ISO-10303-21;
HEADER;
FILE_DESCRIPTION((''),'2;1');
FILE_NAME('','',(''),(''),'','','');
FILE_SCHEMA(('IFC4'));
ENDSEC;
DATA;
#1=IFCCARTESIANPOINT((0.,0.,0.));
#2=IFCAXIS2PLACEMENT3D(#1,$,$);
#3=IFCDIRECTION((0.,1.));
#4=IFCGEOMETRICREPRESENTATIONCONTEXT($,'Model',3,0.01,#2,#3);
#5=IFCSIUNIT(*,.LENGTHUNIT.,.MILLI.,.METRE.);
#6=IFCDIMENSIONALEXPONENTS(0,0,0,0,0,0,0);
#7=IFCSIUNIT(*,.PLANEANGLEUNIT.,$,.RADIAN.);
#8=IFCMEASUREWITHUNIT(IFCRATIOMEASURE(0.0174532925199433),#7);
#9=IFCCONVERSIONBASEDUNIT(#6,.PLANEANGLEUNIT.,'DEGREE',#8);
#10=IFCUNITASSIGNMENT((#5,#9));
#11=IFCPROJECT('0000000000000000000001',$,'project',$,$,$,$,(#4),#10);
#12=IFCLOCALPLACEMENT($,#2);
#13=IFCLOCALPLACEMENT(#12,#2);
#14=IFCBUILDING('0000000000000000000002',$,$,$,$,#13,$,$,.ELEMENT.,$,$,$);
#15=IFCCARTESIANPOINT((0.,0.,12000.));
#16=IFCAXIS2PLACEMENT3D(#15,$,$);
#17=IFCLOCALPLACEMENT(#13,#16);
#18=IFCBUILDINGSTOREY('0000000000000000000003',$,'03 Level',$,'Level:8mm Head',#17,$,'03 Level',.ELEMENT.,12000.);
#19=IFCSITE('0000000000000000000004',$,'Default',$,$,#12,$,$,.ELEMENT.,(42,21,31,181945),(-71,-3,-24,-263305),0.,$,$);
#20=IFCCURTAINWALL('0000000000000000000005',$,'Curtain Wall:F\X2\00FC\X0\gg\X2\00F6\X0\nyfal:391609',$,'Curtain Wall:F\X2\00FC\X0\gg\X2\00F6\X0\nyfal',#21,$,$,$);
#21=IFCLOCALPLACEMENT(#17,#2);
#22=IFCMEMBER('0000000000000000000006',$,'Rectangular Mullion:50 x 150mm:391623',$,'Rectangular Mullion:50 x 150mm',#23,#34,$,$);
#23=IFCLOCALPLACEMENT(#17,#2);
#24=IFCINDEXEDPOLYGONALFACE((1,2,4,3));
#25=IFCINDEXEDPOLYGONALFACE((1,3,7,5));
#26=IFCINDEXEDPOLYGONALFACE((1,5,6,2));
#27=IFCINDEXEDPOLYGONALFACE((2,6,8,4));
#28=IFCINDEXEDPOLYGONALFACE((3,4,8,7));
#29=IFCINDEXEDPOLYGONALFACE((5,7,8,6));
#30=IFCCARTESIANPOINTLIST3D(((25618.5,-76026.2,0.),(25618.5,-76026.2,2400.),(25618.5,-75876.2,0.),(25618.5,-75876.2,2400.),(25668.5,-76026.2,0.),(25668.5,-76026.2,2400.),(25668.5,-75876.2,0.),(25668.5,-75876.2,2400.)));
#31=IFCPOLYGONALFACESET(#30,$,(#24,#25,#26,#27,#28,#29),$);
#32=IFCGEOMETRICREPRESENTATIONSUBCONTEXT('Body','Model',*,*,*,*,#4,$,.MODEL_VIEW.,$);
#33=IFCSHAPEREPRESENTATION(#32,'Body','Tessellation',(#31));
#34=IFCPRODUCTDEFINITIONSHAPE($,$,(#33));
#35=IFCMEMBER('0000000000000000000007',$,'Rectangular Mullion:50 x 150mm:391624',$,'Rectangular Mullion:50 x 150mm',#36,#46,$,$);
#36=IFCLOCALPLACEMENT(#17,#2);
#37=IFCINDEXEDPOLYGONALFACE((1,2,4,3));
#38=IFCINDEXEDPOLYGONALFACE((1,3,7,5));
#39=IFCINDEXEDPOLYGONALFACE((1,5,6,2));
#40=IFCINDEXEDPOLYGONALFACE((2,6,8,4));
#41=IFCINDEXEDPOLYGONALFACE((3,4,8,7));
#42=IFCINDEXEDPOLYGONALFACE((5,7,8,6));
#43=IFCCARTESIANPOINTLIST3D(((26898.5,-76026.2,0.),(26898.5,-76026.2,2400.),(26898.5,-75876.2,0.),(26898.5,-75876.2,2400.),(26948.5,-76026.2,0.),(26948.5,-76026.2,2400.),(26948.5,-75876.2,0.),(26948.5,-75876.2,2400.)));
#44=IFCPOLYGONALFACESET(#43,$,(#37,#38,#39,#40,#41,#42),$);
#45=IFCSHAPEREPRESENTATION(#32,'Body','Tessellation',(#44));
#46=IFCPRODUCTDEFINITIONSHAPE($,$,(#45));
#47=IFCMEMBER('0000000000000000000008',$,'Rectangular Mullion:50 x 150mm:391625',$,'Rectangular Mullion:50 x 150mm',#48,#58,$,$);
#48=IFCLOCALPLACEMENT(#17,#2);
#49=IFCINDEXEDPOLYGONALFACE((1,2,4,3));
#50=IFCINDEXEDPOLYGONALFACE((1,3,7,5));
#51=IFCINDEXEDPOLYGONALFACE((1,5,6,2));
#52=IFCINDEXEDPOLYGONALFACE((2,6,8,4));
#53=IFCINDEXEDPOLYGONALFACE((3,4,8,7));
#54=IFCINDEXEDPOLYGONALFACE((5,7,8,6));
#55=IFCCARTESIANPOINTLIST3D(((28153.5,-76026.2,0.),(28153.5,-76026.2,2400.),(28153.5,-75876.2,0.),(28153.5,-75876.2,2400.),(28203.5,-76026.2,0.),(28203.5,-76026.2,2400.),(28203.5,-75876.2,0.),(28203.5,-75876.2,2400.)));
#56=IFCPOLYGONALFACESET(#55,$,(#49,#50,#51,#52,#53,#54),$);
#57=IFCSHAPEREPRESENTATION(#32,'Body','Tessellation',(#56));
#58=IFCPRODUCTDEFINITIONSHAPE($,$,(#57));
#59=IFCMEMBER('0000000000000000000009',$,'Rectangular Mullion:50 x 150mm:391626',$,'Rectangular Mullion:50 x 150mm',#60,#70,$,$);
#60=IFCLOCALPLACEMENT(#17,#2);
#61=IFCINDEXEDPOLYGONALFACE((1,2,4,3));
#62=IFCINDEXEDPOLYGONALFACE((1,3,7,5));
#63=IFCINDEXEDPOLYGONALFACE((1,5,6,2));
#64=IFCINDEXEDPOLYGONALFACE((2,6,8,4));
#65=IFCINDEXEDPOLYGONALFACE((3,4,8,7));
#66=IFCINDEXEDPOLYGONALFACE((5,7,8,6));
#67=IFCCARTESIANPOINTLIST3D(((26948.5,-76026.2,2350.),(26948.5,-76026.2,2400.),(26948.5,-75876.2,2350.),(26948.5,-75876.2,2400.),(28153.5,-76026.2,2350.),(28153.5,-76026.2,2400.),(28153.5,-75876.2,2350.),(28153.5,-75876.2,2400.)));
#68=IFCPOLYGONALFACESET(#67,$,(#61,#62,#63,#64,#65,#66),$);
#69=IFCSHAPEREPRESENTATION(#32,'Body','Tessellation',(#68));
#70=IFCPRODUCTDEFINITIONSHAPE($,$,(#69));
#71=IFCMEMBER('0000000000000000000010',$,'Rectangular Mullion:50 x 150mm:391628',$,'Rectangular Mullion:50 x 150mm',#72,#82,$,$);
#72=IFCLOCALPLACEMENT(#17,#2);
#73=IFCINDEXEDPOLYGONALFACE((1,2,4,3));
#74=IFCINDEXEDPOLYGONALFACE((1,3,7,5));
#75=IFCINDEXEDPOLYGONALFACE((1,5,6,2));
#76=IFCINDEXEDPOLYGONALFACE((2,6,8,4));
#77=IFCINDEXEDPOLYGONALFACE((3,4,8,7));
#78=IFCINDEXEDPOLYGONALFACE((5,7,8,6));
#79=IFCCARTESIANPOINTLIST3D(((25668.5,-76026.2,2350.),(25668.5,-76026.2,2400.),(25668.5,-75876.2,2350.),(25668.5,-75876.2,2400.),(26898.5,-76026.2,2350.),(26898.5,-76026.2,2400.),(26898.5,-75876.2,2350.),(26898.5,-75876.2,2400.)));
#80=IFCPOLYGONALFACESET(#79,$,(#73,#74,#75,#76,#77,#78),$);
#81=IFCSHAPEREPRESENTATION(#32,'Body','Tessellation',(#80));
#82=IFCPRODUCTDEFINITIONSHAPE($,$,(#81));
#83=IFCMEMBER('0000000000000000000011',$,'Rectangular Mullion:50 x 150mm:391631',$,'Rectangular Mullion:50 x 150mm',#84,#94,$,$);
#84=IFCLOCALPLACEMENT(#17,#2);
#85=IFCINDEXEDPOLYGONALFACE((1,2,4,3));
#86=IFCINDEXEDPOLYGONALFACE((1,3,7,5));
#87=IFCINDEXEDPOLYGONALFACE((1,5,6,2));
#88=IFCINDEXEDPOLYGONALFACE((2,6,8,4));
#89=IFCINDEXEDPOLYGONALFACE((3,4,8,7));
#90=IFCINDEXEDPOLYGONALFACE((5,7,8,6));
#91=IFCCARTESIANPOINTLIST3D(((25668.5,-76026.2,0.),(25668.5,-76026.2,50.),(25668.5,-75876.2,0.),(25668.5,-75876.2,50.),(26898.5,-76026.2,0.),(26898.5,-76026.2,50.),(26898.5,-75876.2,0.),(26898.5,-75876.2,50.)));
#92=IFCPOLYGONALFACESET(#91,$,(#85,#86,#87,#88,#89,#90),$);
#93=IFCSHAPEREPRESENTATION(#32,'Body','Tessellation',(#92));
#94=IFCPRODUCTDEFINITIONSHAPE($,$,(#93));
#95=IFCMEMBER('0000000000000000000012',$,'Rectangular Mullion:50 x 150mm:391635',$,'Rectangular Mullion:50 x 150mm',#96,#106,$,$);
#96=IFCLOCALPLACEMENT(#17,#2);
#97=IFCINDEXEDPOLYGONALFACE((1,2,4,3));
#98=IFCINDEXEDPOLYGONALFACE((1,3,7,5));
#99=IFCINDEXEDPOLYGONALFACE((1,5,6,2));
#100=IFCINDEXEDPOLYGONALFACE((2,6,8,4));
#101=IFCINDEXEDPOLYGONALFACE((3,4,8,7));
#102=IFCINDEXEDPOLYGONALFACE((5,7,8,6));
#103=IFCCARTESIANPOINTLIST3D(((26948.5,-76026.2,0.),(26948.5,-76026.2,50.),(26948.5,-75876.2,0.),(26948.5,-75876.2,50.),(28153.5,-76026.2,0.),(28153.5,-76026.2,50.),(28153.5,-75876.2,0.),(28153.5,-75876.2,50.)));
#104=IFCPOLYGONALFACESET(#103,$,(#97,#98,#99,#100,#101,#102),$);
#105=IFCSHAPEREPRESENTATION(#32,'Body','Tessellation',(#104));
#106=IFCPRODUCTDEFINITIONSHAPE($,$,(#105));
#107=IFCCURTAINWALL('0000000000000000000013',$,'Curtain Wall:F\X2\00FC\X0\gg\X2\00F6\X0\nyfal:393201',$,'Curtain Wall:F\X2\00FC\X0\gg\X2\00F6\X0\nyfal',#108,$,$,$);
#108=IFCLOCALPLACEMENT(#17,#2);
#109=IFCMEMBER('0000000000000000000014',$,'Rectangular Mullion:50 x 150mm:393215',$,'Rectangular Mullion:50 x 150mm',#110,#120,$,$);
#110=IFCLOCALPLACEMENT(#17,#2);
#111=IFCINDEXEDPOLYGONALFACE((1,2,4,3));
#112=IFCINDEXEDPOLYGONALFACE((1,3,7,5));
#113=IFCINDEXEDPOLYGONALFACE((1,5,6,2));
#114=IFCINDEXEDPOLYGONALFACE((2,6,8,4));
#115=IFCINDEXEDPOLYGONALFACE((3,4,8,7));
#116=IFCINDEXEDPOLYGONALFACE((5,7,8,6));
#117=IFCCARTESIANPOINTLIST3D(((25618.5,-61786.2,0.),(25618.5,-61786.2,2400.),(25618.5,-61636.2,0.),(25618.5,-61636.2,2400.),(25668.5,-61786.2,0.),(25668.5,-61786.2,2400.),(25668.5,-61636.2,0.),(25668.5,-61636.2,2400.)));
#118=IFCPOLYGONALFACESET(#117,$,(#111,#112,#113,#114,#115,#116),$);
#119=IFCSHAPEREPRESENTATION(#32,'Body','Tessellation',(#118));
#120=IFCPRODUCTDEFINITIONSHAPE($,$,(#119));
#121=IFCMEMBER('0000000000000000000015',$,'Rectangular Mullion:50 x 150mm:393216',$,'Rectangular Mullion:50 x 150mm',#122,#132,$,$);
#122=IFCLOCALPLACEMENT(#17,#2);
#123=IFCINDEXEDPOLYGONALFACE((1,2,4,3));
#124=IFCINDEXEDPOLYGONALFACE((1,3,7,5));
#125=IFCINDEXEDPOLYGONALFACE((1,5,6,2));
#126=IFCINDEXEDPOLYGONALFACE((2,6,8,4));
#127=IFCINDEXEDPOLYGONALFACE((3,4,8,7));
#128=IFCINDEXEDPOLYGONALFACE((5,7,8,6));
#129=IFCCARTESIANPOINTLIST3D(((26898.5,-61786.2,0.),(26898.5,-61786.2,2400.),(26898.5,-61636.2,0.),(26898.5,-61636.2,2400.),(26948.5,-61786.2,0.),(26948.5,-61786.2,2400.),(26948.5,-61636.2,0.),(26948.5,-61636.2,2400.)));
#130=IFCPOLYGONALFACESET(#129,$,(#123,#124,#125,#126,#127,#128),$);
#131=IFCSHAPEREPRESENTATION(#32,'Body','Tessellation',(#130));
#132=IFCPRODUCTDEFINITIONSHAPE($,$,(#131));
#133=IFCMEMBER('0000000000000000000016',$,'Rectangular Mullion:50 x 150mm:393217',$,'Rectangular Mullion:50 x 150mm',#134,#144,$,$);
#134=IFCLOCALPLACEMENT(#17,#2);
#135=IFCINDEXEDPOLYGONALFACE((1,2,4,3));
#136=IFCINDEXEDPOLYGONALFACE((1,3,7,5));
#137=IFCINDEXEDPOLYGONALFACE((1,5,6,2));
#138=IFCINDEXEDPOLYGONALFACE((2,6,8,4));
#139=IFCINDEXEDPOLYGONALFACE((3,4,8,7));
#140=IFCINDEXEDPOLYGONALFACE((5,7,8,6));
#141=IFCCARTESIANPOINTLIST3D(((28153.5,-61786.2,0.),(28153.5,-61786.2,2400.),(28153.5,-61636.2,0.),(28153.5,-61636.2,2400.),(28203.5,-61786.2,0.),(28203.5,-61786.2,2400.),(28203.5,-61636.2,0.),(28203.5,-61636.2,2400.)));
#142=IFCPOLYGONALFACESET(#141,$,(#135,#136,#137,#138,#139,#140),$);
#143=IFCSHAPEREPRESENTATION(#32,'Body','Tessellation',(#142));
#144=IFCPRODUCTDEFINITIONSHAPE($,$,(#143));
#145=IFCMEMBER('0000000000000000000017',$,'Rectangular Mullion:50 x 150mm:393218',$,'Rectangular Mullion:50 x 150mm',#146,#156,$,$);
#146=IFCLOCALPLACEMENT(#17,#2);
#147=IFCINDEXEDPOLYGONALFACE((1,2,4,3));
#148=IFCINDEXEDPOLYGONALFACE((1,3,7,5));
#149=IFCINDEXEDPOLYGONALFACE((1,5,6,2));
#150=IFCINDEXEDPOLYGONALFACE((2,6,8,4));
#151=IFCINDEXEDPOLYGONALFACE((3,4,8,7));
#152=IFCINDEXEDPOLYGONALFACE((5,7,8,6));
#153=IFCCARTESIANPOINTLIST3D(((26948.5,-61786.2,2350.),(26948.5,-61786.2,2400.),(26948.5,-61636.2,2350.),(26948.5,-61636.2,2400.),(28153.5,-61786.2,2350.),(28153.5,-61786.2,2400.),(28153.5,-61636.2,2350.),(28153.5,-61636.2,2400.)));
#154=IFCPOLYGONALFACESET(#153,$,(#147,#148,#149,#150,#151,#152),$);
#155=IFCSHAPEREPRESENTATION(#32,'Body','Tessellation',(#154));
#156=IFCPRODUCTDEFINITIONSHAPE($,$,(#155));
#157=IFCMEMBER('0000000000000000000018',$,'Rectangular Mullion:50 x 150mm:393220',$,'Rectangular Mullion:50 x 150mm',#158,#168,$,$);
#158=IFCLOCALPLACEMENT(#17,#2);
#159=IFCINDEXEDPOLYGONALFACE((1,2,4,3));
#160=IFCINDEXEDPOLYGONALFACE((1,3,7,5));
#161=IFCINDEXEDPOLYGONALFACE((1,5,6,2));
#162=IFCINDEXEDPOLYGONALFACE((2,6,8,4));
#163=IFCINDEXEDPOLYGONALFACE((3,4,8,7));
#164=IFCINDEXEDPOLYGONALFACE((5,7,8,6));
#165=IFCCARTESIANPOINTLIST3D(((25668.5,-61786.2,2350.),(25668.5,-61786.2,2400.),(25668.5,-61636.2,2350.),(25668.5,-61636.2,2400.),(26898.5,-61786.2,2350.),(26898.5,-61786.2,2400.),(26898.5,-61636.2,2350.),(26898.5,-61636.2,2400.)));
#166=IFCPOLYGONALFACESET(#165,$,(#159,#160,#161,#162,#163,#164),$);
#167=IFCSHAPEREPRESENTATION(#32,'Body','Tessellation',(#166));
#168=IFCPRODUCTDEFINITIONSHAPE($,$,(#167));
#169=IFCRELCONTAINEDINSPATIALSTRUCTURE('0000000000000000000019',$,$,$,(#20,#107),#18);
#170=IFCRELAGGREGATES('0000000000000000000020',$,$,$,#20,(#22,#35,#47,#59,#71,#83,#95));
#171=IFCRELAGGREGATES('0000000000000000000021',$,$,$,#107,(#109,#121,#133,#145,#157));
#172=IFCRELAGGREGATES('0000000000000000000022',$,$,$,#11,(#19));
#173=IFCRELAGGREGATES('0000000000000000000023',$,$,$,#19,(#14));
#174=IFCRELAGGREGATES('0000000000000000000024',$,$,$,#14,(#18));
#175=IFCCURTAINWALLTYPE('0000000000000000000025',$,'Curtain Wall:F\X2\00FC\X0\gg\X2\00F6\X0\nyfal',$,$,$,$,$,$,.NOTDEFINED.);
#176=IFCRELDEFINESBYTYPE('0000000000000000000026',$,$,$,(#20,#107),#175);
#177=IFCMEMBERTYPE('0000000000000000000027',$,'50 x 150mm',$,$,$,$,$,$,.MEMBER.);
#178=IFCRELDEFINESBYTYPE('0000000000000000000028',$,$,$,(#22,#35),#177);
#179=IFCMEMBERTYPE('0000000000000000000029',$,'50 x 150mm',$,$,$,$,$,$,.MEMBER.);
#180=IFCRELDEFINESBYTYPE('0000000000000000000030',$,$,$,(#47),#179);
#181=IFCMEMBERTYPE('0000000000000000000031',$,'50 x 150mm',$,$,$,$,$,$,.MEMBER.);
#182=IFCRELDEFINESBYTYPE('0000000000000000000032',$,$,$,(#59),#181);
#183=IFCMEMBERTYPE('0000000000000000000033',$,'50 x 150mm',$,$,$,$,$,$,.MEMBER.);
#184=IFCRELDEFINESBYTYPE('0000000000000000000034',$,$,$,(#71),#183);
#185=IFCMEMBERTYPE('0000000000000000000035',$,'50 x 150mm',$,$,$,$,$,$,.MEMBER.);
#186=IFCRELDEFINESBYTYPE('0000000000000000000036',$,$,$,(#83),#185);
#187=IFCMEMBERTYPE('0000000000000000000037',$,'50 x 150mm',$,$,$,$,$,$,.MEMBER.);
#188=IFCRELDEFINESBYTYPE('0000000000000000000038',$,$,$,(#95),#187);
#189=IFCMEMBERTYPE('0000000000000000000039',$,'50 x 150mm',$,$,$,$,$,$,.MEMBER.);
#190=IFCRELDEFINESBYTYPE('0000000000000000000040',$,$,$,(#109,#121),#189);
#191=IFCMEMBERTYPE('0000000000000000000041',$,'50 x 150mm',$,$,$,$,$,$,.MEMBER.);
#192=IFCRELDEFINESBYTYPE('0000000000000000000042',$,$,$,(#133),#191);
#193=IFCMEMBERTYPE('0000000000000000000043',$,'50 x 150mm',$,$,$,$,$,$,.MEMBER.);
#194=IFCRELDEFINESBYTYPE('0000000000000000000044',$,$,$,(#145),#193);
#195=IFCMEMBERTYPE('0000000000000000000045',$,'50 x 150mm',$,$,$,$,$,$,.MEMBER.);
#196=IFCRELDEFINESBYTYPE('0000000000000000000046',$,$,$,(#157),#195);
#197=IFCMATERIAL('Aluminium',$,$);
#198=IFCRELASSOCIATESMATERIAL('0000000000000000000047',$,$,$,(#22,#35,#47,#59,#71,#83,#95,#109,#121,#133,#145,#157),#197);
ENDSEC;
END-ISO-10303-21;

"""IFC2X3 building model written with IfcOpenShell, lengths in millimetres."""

from ifc_helpers import new_model, entity, si_unit, converted_unit, direction, frame, origin, origin_2d_with_axis, place, context, subcontext, project, spatial, rectangle, extrude, source, transform, mapped, material, type_object, type_shapes, element, aggregate, save


model = new_model("IFC2X3")

# Units and contexts
model_context = context("Model", 3, precision=0.01, world=origin(), true_north=direction((0.0, 1.0)))
body_context = subcontext(model_context, "Body", "Model", "MODEL_VIEW")
ifc_project = project(units=[si_unit("LENGTHUNIT", "METRE", prefix="MILLI"), converted_unit("PLANEANGLEUNIT", "DEGREE", entity("IfcRatioMeasure", 0.0174532925199433), si_unit("PLANEANGLEUNIT", "RADIAN"), dimensions=[0, 0, 0, 0, 0, 0, 0])], contexts=[model_context])

# Site, building, storey
site_placement = place(None, origin())
site = spatial("IfcSite", under=ifc_project, at=site_placement, Name="Default", CompositionType="ELEMENT", RefLatitude=(42, 21, 31, 181945), RefLongitude=(-71, -3, -24, -263305), RefElevation=0.0)
building_placement = place(site_placement, origin())
building = spatial("IfcBuilding", under=site, at=building_placement, CompositionType="ELEMENT")
storey_placement = place(building_placement, frame((0.0, 0.0, 12000.0)))
storey = spatial("IfcBuildingStorey", under=building, at=storey_placement, Name="03 Level", ObjectType="Level:8mm Head", LongName="03 Level", CompositionType="ELEMENT", Elevation=12000.0)

# Curtain walls, members
curtain_wall_type = type_object("IfcCurtainWallType", Name="Curtain Wall:Függönyfal", PredefinedType="NOTDEFINED")
curtain_wall_1_placement = place(storey_placement, frame((0.0, 0.0, -12000.0)))
curtain_wall_1 = element("IfcCurtainWall", 1, at=curtain_wall_1_placement, inside=storey, type_object=curtain_wall_type, Name="Curtain Wall:Függönyfal:391609", ObjectType="Curtain Wall:Függönyfal")
ifc_material_1 = material(Name="Aluminium")
member_type_1 = type_object("IfcMemberType", Name="50 x 150mm", PredefinedType="MEMBER")
shared_shape_1 = source(origin(), body_context, "Body", "SweptSolid", [
    extrude(rectangle(XDim=150.0, YDim=50.0, at=origin_2d_with_axis()), frame((0.0, 0.0, -2400.0), z_axis=(0.0, 0.0, 1.0), x_axis=(0.0, -1.0, 0.0)), (0.0, 0.0, 1.0), 2400.0),
])
type_shapes(member_type_1, [shared_shape_1])
member_1_placement = place(storey_placement, frame((25643.5, -75951.2, 0.0), z_axis=(0.0, 0.0, -1.0), x_axis=(-1.0, 0.0, 0.0)))
member_1 = element("IfcMember", 2, at=member_1_placement, type_object=member_type_1, material=ifc_material_1, Name="Rectangular Mullion:50 x 150mm:391623", ObjectType="Rectangular Mullion:50 x 150mm", context=body_context, shape_type="MappedRepresentation", body=[
    mapped(shared_shape_1, transform((0.0, 0.0, 0.0), scale=1.0)),
])
member_2_placement = place(storey_placement, frame((26923.5, -75951.2, 0.0), z_axis=(0.0, 0.0, -1.0), x_axis=(-1.0, 0.0, 0.0)))
member_2 = element("IfcMember", 3, at=member_2_placement, type_object=member_type_1, material=ifc_material_1, Name="Rectangular Mullion:50 x 150mm:391624", ObjectType="Rectangular Mullion:50 x 150mm", context=body_context, shape_type="MappedRepresentation", body=[
    mapped(shared_shape_1, transform((0.0, 0.0, 0.0), scale=1.0)),
])
member_type_2 = type_object("IfcMemberType", Name="50 x 150mm", PredefinedType="MEMBER")
shared_shape_2 = source(origin(), body_context, "Body", "SweptSolid", [
    extrude(rectangle(XDim=150.0, YDim=50.0, at=origin_2d_with_axis()), frame((-25.0, 0.0, -2400.0), z_axis=(0.0, 0.0, 1.0), x_axis=(0.0, -1.0, 0.0)), (0.0, 0.0, 1.0), 2400.0),
])
type_shapes(member_type_2, [shared_shape_2])
member_3_placement = place(storey_placement, frame((28203.5, -75951.2, 2400.0)))
member_3 = element("IfcMember", 4, at=member_3_placement, type_object=member_type_2, material=ifc_material_1, Name="Rectangular Mullion:50 x 150mm:391625", ObjectType="Rectangular Mullion:50 x 150mm", context=body_context, shape_type="MappedRepresentation", body=[
    mapped(shared_shape_2, transform((0.0, 0.0, 0.0), scale=1.0)),
])
member_type_3 = type_object("IfcMemberType", Name="50 x 150mm", PredefinedType="MEMBER")
shared_shape_3 = source(origin(), body_context, "Body", "SweptSolid", [
    extrude(rectangle(XDim=150.0, YDim=50.0, at=origin_2d_with_axis()), frame((-25.0, 0.0, -1205.0), z_axis=(0.0, 0.0, 1.0), x_axis=(0.0, -1.0, 0.0)), (0.0, 0.0, 1.0), 1205.0),
])
type_shapes(member_type_3, [shared_shape_3])
member_4_placement = place(storey_placement, frame((26948.5, -75951.2, 2400.0), z_axis=(-1.0, 0.0, 0.0), x_axis=(0.0, 0.0, 1.0)))
member_4 = element("IfcMember", 5, at=member_4_placement, type_object=member_type_3, material=ifc_material_1, Name="Rectangular Mullion:50 x 150mm:391626", ObjectType="Rectangular Mullion:50 x 150mm", context=body_context, shape_type="MappedRepresentation", body=[
    mapped(shared_shape_3, transform((0.0, 0.0, 0.0), scale=1.0)),
])
member_type_4 = type_object("IfcMemberType", Name="50 x 150mm", PredefinedType="MEMBER")
shared_shape_4 = source(origin(), body_context, "Body", "SweptSolid", [
    extrude(rectangle(XDim=150.0, YDim=50.0, at=origin_2d_with_axis()), frame((-25.0, 0.0, -1230.0), z_axis=(0.0, 0.0, 1.0), x_axis=(0.0, -1.0, 0.0)), (0.0, 0.0, 1.0), 1230.0),
])
type_shapes(member_type_4, [shared_shape_4])
member_5_placement = place(storey_placement, frame((25668.5, -75951.2, 2400.0), z_axis=(-1.0, 0.0, 0.0), x_axis=(0.0, 0.0, 1.0)))
member_5 = element("IfcMember", 6, at=member_5_placement, type_object=member_type_4, material=ifc_material_1, Name="Rectangular Mullion:50 x 150mm:391628", ObjectType="Rectangular Mullion:50 x 150mm", context=body_context, shape_type="MappedRepresentation", body=[
    mapped(shared_shape_4, transform((0.0, 0.0, 0.0), scale=1.0)),
])
member_type_5 = type_object("IfcMemberType", Name="50 x 150mm", PredefinedType="MEMBER")
shared_shape_5 = source(origin(), body_context, "Body", "SweptSolid", [
    extrude(rectangle(XDim=150.0, YDim=50.0, at=origin_2d_with_axis()), frame((-25.0, 0.0, -1230.0), z_axis=(0.0, 0.0, 1.0), x_axis=(0.0, -1.0, 0.0)), (0.0, 0.0, 1.0), 1230.0),
])
type_shapes(member_type_5, [shared_shape_5])
member_6_placement = place(storey_placement, frame((26898.5, -75951.2, 0.0), z_axis=(1.0, 0.0, 0.0), x_axis=(0.0, 0.0, -1.0)))
member_6 = element("IfcMember", 7, at=member_6_placement, type_object=member_type_5, material=ifc_material_1, Name="Rectangular Mullion:50 x 150mm:391631", ObjectType="Rectangular Mullion:50 x 150mm", context=body_context, shape_type="MappedRepresentation", body=[
    mapped(shared_shape_5, transform((0.0, 0.0, 0.0), scale=1.0)),
])
member_type_6 = type_object("IfcMemberType", Name="50 x 150mm", PredefinedType="MEMBER")
shared_shape_6 = source(origin(), body_context, "Body", "SweptSolid", [
    extrude(rectangle(XDim=150.0, YDim=50.0, at=origin_2d_with_axis()), frame((-25.0, 0.0, -1205.0), z_axis=(0.0, 0.0, 1.0), x_axis=(0.0, -1.0, 0.0)), (0.0, 0.0, 1.0), 1205.0),
])
type_shapes(member_type_6, [shared_shape_6])
member_7_placement = place(storey_placement, frame((28153.5, -75951.2, 0.0), z_axis=(1.0, 0.0, 0.0), x_axis=(0.0, 0.0, -1.0)))
member_7 = element("IfcMember", 8, at=member_7_placement, type_object=member_type_6, material=ifc_material_1, Name="Rectangular Mullion:50 x 150mm:391635", ObjectType="Rectangular Mullion:50 x 150mm", context=body_context, shape_type="MappedRepresentation", body=[
    mapped(shared_shape_6, transform((0.0, 0.0, 0.0), scale=1.0)),
])
curtain_wall_2_placement = place(storey_placement, frame((0.0, 0.0, -12000.0)))
curtain_wall_2 = element("IfcCurtainWall", 9, at=curtain_wall_2_placement, inside=storey, type_object=curtain_wall_type, Name="Curtain Wall:Függönyfal:393201", ObjectType="Curtain Wall:Függönyfal")
member_type_7 = type_object("IfcMemberType", Name="50 x 150mm", PredefinedType="MEMBER")
shared_shape_7 = source(origin(), body_context, "Body", "SweptSolid", [
    extrude(rectangle(XDim=150.0, YDim=50.0, at=origin_2d_with_axis()), frame((0.0, 0.0, -2400.0), z_axis=(0.0, 0.0, 1.0), x_axis=(0.0, -1.0, 0.0)), (0.0, 0.0, 1.0), 2400.0),
])
type_shapes(member_type_7, [shared_shape_7])
member_8_placement = place(storey_placement, frame((25643.5, -61711.2, 0.0), z_axis=(0.0, 0.0, -1.0), x_axis=(-1.0, 0.0, 0.0)))
member_8 = element("IfcMember", 10, at=member_8_placement, type_object=member_type_7, material=ifc_material_1, Name="Rectangular Mullion:50 x 150mm:393215", ObjectType="Rectangular Mullion:50 x 150mm", context=body_context, shape_type="MappedRepresentation", body=[
    mapped(shared_shape_7, transform((0.0, 0.0, 0.0), scale=1.0)),
])
member_9_placement = place(storey_placement, frame((26923.5, -61711.2, 0.0), z_axis=(0.0, 0.0, -1.0), x_axis=(-1.0, 0.0, 0.0)))
member_9 = element("IfcMember", 11, at=member_9_placement, type_object=member_type_7, material=ifc_material_1, Name="Rectangular Mullion:50 x 150mm:393216", ObjectType="Rectangular Mullion:50 x 150mm", context=body_context, shape_type="MappedRepresentation", body=[
    mapped(shared_shape_7, transform((0.0, 0.0, 0.0), scale=1.0)),
])
member_type_8 = type_object("IfcMemberType", Name="50 x 150mm", PredefinedType="MEMBER")
shared_shape_8 = source(origin(), body_context, "Body", "SweptSolid", [
    extrude(rectangle(XDim=150.0, YDim=50.0, at=origin_2d_with_axis()), frame((-25.0, 0.0, -2400.0), z_axis=(0.0, 0.0, 1.0), x_axis=(0.0, -1.0, 0.0)), (0.0, 0.0, 1.0), 2400.0),
])
type_shapes(member_type_8, [shared_shape_8])
member_10_placement = place(storey_placement, frame((28203.5, -61711.2, 2400.0)))
member_10 = element("IfcMember", 12, at=member_10_placement, type_object=member_type_8, material=ifc_material_1, Name="Rectangular Mullion:50 x 150mm:393217", ObjectType="Rectangular Mullion:50 x 150mm", context=body_context, shape_type="MappedRepresentation", body=[
    mapped(shared_shape_8, transform((0.0, 0.0, 0.0), scale=1.0)),
])
member_type_9 = type_object("IfcMemberType", Name="50 x 150mm", PredefinedType="MEMBER")
shared_shape_9 = source(origin(), body_context, "Body", "SweptSolid", [
    extrude(rectangle(XDim=150.0, YDim=50.0, at=origin_2d_with_axis()), frame((-25.0, 0.0, -1205.0), z_axis=(0.0, 0.0, 1.0), x_axis=(0.0, -1.0, 0.0)), (0.0, 0.0, 1.0), 1205.0),
])
type_shapes(member_type_9, [shared_shape_9])
member_11_placement = place(storey_placement, frame((26948.5, -61711.2, 2400.0), z_axis=(-1.0, 0.0, 0.0), x_axis=(0.0, 0.0, 1.0)))
member_11 = element("IfcMember", 13, at=member_11_placement, type_object=member_type_9, material=ifc_material_1, Name="Rectangular Mullion:50 x 150mm:393218", ObjectType="Rectangular Mullion:50 x 150mm", context=body_context, shape_type="MappedRepresentation", body=[
    mapped(shared_shape_9, transform((0.0, 0.0, 0.0), scale=1.0)),
])
member_type_10 = type_object("IfcMemberType", Name="50 x 150mm", PredefinedType="MEMBER")
shared_shape_10 = source(origin(), body_context, "Body", "SweptSolid", [
    extrude(rectangle(XDim=150.0, YDim=50.0, at=origin_2d_with_axis()), frame((-25.0, 0.0, -1230.0), z_axis=(0.0, 0.0, 1.0), x_axis=(0.0, -1.0, 0.0)), (0.0, 0.0, 1.0), 1230.0),
])
type_shapes(member_type_10, [shared_shape_10])
member_12_placement = place(storey_placement, frame((25668.5, -61711.2, 2400.0), z_axis=(-1.0, 0.0, 0.0), x_axis=(0.0, 0.0, 1.0)))
member_12 = element("IfcMember", 14, at=member_12_placement, type_object=member_type_10, material=ifc_material_1, Name="Rectangular Mullion:50 x 150mm:393220", ObjectType="Rectangular Mullion:50 x 150mm", context=body_context, shape_type="MappedRepresentation", body=[
    mapped(shared_shape_10, transform((0.0, 0.0, 0.0), scale=1.0)),
])

aggregate(curtain_wall_1, [member_1, member_2, member_3, member_4, member_5, member_6, member_7])
aggregate(curtain_wall_2, [member_8, member_9, member_10, member_11, member_12])

save(model, "model.ifc")
